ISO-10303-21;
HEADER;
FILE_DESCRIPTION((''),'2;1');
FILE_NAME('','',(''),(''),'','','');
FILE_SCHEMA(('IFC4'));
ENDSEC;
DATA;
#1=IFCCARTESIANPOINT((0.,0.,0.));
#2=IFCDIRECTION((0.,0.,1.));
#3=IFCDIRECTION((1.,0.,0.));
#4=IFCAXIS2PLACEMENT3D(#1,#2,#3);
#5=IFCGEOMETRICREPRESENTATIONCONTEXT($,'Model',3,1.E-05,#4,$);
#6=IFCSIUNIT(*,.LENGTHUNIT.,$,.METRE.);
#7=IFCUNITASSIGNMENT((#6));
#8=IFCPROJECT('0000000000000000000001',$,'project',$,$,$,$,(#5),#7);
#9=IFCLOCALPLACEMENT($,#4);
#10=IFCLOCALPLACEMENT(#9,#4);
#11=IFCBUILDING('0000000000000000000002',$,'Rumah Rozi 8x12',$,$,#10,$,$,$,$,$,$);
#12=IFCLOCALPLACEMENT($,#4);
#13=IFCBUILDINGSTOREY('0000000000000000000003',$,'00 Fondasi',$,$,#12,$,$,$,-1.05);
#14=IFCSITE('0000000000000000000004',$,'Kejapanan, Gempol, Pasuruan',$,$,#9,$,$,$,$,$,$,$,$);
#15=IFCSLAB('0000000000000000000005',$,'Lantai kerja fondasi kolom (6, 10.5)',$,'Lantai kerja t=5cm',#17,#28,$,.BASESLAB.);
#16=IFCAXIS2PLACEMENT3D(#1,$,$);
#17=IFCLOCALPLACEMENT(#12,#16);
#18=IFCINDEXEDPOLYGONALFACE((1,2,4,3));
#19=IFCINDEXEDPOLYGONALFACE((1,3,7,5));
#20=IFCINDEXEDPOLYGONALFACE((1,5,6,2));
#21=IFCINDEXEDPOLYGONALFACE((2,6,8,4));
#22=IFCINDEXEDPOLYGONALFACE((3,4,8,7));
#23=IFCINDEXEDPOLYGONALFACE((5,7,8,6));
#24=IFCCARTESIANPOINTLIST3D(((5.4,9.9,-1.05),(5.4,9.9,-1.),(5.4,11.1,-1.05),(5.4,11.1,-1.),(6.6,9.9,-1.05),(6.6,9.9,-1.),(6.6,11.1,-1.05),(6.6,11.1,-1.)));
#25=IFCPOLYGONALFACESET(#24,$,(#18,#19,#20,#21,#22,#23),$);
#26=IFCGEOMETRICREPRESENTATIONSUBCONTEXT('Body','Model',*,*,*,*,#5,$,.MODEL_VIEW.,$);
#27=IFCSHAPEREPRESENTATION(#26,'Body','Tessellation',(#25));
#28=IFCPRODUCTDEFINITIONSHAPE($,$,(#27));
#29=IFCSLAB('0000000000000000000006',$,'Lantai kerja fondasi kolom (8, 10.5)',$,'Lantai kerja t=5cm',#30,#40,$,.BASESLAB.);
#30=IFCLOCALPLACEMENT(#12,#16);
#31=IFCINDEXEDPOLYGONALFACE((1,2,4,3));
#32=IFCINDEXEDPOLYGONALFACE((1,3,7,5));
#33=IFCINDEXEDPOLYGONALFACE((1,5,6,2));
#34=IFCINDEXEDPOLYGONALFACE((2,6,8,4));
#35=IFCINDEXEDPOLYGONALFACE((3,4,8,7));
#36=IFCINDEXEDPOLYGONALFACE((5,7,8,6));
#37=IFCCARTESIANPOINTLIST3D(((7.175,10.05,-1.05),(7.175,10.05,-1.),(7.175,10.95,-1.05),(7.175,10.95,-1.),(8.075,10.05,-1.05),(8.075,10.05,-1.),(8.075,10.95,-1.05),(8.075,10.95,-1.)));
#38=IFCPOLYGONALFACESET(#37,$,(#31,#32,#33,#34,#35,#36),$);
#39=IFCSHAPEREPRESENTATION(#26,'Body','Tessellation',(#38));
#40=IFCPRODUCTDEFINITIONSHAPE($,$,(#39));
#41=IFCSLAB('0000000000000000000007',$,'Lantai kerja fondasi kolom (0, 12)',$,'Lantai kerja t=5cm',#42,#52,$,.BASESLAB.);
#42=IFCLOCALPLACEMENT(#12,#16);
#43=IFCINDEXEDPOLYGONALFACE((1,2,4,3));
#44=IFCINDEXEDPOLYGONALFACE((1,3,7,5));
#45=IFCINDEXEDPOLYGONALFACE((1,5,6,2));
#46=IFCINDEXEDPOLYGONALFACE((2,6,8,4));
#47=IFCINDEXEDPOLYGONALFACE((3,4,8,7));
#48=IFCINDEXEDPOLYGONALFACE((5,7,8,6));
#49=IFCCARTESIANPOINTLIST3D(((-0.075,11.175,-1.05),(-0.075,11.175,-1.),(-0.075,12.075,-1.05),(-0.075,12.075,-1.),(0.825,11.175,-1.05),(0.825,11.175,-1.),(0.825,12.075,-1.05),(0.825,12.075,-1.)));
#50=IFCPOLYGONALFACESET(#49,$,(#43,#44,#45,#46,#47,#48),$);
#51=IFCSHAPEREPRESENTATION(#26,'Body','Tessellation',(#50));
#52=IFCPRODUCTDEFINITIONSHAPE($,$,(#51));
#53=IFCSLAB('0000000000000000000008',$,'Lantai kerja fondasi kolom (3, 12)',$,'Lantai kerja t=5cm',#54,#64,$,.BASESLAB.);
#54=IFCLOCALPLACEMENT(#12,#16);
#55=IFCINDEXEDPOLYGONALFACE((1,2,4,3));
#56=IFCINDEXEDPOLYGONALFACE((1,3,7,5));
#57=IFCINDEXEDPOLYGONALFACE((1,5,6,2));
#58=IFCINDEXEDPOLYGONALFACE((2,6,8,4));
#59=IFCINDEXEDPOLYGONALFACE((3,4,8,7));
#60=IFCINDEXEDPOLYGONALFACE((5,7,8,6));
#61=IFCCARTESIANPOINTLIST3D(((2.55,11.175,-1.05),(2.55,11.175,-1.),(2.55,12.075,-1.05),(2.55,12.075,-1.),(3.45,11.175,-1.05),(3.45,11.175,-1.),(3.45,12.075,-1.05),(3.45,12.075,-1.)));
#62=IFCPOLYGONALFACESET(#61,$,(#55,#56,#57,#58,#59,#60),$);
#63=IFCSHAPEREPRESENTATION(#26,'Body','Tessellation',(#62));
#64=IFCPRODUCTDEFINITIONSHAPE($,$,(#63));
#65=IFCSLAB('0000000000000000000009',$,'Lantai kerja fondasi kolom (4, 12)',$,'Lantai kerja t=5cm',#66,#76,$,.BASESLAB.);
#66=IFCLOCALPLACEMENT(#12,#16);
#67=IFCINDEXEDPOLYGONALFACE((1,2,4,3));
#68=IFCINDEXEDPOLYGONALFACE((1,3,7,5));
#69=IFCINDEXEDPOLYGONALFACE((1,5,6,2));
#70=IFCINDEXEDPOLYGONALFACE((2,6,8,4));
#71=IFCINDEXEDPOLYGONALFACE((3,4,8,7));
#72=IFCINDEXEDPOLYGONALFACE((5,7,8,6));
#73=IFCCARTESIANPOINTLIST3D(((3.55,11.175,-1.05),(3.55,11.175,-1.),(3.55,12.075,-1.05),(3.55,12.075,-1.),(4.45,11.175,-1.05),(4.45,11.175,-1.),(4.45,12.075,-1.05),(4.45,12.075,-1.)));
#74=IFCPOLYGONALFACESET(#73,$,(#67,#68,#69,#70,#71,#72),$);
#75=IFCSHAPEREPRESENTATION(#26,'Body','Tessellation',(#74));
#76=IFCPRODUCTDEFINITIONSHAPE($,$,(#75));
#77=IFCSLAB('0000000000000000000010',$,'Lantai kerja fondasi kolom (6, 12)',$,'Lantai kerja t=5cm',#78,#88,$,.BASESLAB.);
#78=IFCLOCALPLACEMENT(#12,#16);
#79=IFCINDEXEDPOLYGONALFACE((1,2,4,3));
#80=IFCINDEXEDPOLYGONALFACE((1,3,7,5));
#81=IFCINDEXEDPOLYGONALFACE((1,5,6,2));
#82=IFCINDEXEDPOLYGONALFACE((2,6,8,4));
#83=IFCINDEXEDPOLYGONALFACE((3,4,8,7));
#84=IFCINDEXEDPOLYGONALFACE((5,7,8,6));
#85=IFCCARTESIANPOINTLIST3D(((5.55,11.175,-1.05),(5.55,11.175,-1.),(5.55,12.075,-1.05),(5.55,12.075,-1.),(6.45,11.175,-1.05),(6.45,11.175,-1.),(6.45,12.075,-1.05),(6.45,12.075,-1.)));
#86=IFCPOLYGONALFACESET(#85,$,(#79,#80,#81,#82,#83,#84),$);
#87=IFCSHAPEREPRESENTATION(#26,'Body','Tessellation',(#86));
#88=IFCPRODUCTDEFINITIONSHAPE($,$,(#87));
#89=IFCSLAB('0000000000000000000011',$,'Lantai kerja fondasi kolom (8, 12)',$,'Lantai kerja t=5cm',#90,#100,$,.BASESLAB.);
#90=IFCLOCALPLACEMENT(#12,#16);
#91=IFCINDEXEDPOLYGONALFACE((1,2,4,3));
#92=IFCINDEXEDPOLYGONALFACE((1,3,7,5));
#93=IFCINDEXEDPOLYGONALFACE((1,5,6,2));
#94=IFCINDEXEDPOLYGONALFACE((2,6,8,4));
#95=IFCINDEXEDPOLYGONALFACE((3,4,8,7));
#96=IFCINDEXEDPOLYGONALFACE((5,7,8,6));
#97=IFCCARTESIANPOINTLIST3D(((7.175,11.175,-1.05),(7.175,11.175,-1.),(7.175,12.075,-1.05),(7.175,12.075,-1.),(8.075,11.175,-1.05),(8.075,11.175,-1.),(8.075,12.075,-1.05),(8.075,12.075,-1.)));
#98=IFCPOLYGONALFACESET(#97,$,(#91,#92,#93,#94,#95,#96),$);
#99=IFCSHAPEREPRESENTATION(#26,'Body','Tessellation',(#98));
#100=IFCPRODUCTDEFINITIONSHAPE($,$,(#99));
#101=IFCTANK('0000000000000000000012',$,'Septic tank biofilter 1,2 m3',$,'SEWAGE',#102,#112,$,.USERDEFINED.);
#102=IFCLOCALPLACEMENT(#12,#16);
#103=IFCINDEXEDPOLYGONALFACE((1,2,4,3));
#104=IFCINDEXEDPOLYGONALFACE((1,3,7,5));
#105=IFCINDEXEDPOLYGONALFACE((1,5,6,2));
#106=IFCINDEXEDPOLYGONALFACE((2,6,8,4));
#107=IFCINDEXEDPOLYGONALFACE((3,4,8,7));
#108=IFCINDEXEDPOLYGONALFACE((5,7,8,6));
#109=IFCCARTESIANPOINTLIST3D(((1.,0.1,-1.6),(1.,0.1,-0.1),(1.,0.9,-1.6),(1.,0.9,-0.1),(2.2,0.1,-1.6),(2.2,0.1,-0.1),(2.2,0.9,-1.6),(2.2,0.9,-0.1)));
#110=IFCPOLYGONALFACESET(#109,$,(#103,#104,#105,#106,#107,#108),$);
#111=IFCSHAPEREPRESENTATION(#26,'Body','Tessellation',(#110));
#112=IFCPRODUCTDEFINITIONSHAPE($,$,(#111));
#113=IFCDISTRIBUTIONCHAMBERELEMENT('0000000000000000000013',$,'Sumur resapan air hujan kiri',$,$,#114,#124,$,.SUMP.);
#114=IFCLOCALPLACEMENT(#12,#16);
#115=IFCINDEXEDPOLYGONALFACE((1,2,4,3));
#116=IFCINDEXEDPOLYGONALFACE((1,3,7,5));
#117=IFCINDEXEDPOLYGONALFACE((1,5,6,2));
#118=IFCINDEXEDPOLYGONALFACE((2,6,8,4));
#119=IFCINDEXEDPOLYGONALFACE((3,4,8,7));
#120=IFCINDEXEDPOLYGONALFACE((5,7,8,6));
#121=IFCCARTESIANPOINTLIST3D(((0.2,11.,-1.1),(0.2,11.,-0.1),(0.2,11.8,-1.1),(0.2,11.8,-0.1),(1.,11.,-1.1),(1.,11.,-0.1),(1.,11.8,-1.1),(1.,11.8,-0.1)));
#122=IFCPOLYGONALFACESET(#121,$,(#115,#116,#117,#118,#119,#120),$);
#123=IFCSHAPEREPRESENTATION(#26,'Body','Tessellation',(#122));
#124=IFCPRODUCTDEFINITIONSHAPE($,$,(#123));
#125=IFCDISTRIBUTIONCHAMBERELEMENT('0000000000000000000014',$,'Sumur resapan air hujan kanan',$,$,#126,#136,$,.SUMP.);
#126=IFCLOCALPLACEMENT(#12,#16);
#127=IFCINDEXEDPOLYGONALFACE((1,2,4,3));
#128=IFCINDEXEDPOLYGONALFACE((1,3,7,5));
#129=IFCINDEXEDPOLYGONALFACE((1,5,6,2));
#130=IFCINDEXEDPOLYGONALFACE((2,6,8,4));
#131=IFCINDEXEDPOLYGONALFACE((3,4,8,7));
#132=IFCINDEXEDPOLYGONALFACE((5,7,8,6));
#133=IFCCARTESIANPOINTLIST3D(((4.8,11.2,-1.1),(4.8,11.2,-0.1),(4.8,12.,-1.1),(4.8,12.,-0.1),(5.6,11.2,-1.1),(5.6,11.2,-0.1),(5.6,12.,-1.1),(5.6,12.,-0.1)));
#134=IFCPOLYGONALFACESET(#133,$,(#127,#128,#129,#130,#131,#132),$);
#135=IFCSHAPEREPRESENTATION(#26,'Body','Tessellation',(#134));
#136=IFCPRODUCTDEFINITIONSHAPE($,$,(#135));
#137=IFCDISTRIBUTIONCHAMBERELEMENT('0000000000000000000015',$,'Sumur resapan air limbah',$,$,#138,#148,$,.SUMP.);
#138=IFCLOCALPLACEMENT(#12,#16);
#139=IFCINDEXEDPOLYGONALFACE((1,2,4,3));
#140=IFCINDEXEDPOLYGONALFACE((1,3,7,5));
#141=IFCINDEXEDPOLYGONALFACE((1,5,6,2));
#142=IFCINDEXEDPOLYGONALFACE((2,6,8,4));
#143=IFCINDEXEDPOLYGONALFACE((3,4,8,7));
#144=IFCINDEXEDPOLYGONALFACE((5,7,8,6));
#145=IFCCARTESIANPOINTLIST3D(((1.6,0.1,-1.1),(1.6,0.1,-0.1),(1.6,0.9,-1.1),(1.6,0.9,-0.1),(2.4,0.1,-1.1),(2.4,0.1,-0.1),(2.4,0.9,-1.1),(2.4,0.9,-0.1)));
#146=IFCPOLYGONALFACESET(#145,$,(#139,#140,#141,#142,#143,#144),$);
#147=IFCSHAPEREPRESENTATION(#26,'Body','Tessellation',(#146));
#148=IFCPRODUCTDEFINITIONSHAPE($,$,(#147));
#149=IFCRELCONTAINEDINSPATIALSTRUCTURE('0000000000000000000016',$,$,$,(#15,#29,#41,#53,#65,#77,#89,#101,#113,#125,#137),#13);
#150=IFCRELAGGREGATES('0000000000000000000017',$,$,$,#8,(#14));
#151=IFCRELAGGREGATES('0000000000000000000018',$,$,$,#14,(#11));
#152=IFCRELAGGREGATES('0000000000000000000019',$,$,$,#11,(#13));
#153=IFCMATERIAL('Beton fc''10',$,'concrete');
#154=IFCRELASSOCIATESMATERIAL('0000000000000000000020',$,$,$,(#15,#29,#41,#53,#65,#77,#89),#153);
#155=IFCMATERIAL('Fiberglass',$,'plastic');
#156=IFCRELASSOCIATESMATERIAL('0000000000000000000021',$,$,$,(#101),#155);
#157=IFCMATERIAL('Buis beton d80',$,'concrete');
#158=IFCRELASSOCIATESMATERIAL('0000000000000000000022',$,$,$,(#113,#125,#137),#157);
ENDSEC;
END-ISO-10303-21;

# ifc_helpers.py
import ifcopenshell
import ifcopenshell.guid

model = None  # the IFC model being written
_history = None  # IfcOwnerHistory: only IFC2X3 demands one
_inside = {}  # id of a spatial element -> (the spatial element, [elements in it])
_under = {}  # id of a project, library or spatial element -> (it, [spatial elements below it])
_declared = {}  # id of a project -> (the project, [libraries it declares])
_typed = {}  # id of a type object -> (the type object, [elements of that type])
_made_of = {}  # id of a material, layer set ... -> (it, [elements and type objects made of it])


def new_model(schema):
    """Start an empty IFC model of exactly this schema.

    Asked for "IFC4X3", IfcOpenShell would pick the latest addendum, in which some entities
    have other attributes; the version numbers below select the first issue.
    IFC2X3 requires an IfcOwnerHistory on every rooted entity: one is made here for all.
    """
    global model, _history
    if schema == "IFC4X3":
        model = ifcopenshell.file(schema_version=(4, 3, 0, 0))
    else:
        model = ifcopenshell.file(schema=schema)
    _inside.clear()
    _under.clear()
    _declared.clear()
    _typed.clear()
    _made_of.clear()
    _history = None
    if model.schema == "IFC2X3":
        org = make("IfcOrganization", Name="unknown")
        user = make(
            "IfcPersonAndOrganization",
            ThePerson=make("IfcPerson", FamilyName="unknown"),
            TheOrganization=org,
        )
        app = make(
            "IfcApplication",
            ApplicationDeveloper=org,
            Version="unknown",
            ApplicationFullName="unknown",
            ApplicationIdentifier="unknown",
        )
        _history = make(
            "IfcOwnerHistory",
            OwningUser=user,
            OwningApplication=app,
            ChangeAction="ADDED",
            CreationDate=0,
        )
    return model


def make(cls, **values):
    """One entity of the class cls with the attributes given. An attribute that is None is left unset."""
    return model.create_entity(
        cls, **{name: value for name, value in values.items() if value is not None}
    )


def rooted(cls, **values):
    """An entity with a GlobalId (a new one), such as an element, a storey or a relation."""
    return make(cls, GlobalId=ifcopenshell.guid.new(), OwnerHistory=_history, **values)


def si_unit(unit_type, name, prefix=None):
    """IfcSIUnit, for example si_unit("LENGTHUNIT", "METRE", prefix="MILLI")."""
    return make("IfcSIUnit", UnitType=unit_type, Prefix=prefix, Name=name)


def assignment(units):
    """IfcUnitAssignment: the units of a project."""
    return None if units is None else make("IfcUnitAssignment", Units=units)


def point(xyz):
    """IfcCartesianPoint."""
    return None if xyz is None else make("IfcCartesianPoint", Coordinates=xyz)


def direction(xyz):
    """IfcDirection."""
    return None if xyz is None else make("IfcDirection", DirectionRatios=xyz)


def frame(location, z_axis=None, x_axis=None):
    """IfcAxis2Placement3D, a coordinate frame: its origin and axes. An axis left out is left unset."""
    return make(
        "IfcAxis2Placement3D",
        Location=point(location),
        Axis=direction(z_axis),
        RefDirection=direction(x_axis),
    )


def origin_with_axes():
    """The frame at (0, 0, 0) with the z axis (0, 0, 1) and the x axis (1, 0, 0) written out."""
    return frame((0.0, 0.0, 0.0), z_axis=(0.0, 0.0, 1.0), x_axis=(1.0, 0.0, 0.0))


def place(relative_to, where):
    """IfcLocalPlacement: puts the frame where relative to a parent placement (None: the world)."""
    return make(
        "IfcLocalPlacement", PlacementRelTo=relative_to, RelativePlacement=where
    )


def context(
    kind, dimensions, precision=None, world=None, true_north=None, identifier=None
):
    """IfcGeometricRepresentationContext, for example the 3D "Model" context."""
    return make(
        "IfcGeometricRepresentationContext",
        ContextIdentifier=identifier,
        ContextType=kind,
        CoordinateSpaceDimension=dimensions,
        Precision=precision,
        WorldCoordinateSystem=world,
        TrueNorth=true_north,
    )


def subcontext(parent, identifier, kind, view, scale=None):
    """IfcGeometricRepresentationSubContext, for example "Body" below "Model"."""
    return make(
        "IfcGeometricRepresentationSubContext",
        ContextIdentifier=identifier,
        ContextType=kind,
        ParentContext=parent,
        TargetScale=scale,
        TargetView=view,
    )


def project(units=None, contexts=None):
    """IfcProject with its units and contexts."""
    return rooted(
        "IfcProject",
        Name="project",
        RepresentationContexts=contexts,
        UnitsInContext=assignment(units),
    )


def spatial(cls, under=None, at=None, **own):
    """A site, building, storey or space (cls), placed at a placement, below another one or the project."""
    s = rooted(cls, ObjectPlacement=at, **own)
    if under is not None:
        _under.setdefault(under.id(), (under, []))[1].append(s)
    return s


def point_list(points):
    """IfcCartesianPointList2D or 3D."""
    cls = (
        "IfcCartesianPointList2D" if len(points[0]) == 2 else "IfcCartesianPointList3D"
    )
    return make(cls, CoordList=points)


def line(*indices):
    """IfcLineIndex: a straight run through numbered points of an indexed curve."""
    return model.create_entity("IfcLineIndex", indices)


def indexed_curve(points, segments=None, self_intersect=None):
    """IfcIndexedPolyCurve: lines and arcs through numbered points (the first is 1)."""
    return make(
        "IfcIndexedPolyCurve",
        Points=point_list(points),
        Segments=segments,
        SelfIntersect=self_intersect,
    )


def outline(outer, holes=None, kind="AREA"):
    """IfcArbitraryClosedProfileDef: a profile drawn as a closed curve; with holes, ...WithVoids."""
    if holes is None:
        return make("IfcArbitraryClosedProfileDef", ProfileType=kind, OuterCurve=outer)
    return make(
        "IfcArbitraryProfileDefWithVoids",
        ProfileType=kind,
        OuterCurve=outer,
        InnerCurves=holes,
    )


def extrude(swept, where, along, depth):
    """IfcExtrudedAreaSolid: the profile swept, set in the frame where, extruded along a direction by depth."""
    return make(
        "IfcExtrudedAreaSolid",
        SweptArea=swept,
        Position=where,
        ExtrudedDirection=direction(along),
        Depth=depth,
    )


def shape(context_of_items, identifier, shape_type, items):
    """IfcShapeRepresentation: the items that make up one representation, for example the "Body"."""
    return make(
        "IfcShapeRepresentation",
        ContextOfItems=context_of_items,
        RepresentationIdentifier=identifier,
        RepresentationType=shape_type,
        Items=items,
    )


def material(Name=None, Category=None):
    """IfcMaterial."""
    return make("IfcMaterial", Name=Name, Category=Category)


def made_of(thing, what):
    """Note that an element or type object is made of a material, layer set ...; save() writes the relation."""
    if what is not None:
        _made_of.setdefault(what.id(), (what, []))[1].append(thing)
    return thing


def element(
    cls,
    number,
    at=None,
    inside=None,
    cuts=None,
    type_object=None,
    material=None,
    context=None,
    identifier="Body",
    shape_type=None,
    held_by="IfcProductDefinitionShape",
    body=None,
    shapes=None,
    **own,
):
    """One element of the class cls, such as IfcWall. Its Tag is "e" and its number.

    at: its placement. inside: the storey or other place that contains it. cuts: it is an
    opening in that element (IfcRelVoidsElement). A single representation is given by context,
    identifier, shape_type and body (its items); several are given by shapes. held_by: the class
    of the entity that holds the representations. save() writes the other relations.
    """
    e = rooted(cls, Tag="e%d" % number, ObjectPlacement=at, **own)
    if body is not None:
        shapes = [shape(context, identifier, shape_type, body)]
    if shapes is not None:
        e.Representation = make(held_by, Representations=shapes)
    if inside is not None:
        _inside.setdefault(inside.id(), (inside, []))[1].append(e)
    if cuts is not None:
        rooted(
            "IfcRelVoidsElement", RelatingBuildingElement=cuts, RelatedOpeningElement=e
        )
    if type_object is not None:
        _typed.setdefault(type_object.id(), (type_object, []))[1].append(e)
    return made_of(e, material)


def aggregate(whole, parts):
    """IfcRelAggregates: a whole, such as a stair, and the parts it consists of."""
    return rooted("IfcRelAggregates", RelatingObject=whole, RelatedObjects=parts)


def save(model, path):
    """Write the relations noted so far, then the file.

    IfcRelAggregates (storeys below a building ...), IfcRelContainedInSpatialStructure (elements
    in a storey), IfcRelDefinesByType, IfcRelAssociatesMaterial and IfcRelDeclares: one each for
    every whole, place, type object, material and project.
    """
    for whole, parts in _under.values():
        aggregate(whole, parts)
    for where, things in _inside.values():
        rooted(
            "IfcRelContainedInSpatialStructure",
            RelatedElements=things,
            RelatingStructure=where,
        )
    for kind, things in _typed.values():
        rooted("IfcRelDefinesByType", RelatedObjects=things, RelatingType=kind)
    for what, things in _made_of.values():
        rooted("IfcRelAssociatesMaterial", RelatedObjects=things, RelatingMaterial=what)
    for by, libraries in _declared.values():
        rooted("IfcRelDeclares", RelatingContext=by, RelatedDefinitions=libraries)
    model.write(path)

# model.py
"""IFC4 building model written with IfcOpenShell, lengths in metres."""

from ifc_helpers import new_model, si_unit, frame, origin_with_axes, place, context, subcontext, project, spatial, line, indexed_curve, outline, extrude, material, element, save


model = new_model("IFC4")

# Units and contexts
model_context = context("Model", 3, precision=1e-05, world=origin_with_axes())
body_context = subcontext(model_context, "Body", "Model", "MODEL_VIEW")
ifc_project = project(units=[si_unit("LENGTHUNIT", "METRE")], contexts=[model_context])

# Site, building, storey
site_placement = place(None, origin_with_axes())
site = spatial("IfcSite", under=ifc_project, at=site_placement, Name="Kejapanan, Gempol, Pasuruan")
building_placement = place(site_placement, origin_with_axes())
building = spatial("IfcBuilding", under=site, at=building_placement, Name="Rumah Rozi 8x12")
storey_placement = place(None, origin_with_axes())
storey = spatial("IfcBuildingStorey", under=building, at=storey_placement, Name="00 Fondasi", Elevation=-1.05)

# Slabs
ifc_material_1 = material(Name="Beton fc'10", Category="concrete")
slab_1_placement = place(storey_placement, origin_with_axes())
element("IfcSlab", 1, at=slab_1_placement, inside=storey, material=ifc_material_1, Name="Lantai kerja fondasi kolom (6, 10.5)", ObjectType="Lantai kerja t=5cm", PredefinedType="BASESLAB", context=body_context, shape_type="SweptSolid", body=[
    extrude(outline(indexed_curve([(5.4, 9.9), (6.6, 9.9), (6.6, 11.1), (5.4, 11.1)], segments=[line(1, 2, 3, 4, 1)])), frame((0.0, 0.0, -1.05), z_axis=(0.0, 0.0, 1.0), x_axis=(1.0, 0.0, 0.0)), (0.0, 0.0, 1.0), 0.05),
])
slab_2_placement = place(storey_placement, origin_with_axes())
element("IfcSlab", 2, at=slab_2_placement, inside=storey, material=ifc_material_1, Name="Lantai kerja fondasi kolom (8, 10.5)", ObjectType="Lantai kerja t=5cm", PredefinedType="BASESLAB", context=body_context, shape_type="SweptSolid", body=[
    extrude(outline(indexed_curve([(7.175, 10.05), (8.075, 10.05), (8.075, 10.95), (7.175, 10.95)], segments=[line(1, 2, 3, 4, 1)])), frame((0.0, 0.0, -1.05), z_axis=(0.0, 0.0, 1.0), x_axis=(1.0, 0.0, 0.0)), (0.0, 0.0, 1.0), 0.05),
])
slab_3_placement = place(storey_placement, origin_with_axes())
element("IfcSlab", 3, at=slab_3_placement, inside=storey, material=ifc_material_1, Name="Lantai kerja fondasi kolom (0, 12)", ObjectType="Lantai kerja t=5cm", PredefinedType="BASESLAB", context=body_context, shape_type="SweptSolid", body=[
    extrude(outline(indexed_curve([(-0.075, 11.175), (0.825, 11.175), (0.825, 12.075), (-0.075, 12.075)], segments=[line(1, 2, 3, 4, 1)])), frame((0.0, 0.0, -1.05), z_axis=(0.0, 0.0, 1.0), x_axis=(1.0, 0.0, 0.0)), (0.0, 0.0, 1.0), 0.05),
])
slab_4_placement = place(storey_placement, origin_with_axes())
element("IfcSlab", 4, at=slab_4_placement, inside=storey, material=ifc_material_1, Name="Lantai kerja fondasi kolom (3, 12)", ObjectType="Lantai kerja t=5cm", PredefinedType="BASESLAB", context=body_context, shape_type="SweptSolid", body=[
    extrude(outline(indexed_curve([(2.55, 11.175), (3.45, 11.175), (3.45, 12.075), (2.55, 12.075)], segments=[line(1, 2, 3, 4, 1)])), frame((0.0, 0.0, -1.05), z_axis=(0.0, 0.0, 1.0), x_axis=(1.0, 0.0, 0.0)), (0.0, 0.0, 1.0), 0.05),
])
slab_5_placement = place(storey_placement, origin_with_axes())
element("IfcSlab", 5, at=slab_5_placement, inside=storey, material=ifc_material_1, Name="Lantai kerja fondasi kolom (4, 12)", ObjectType="Lantai kerja t=5cm", PredefinedType="BASESLAB", context=body_context, shape_type="SweptSolid", body=[
    extrude(outline(indexed_curve([(3.55, 11.175), (4.45, 11.175), (4.45, 12.075), (3.55, 12.075)], segments=[line(1, 2, 3, 4, 1)])), frame((0.0, 0.0, -1.05), z_axis=(0.0, 0.0, 1.0), x_axis=(1.0, 0.0, 0.0)), (0.0, 0.0, 1.0), 0.05),
])
slab_6_placement = place(storey_placement, origin_with_axes())
element("IfcSlab", 6, at=slab_6_placement, inside=storey, material=ifc_material_1, Name="Lantai kerja fondasi kolom (6, 12)", ObjectType="Lantai kerja t=5cm", PredefinedType="BASESLAB", context=body_context, shape_type="SweptSolid", body=[
    extrude(outline(indexed_curve([(5.55, 11.175), (6.45, 11.175), (6.45, 12.075), (5.55, 12.075)], segments=[line(1, 2, 3, 4, 1)])), frame((0.0, 0.0, -1.05), z_axis=(0.0, 0.0, 1.0), x_axis=(1.0, 0.0, 0.0)), (0.0, 0.0, 1.0), 0.05),
])
slab_7_placement = place(storey_placement, origin_with_axes())
element("IfcSlab", 7, at=slab_7_placement, inside=storey, material=ifc_material_1, Name="Lantai kerja fondasi kolom (8, 12)", ObjectType="Lantai kerja t=5cm", PredefinedType="BASESLAB", context=body_context, shape_type="SweptSolid", body=[
    extrude(outline(indexed_curve([(7.175, 11.175), (8.075, 11.175), (8.075, 12.075), (7.175, 12.075)], segments=[line(1, 2, 3, 4, 1)])), frame((0.0, 0.0, -1.05), z_axis=(0.0, 0.0, 1.0), x_axis=(1.0, 0.0, 0.0)), (0.0, 0.0, 1.0), 0.05),
])

# Tank
ifc_material_2 = material(Name="Fiberglass", Category="plastic")
tank_placement = place(storey_placement, origin_with_axes())
element("IfcTank", 8, at=tank_placement, inside=storey, material=ifc_material_2, Name="Septic tank biofilter 1,2 m3", ObjectType="SEWAGE", PredefinedType="USERDEFINED", context=body_context, shape_type="SweptSolid", body=[
    extrude(outline(indexed_curve([(1.0, 0.1), (2.2, 0.1), (2.2, 0.9), (1.0, 0.9)], segments=[line(1, 2, 3, 4, 1)])), frame((0.0, 0.0, -1.6), z_axis=(0.0, 0.0, 1.0), x_axis=(1.0, 0.0, 0.0)), (0.0, 0.0, 1.0), 1.5),
])

# Distribution chamber elements
ifc_material_3 = material(Name="Buis beton d80", Category="concrete")
distribution_chamber_element_1_placement = place(storey_placement, origin_with_axes())
element("IfcDistributionChamberElement", 9, at=distribution_chamber_element_1_placement, inside=storey, material=ifc_material_3, Name="Sumur resapan air hujan kiri", PredefinedType="SUMP", context=body_context, shape_type="SweptSolid", body=[
    extrude(outline(indexed_curve([(0.2, 11.0), (1.0, 11.0), (1.0, 11.8), (0.2, 11.8)], segments=[line(1, 2, 3, 4, 1)])), frame((0.0, 0.0, -1.1), z_axis=(0.0, 0.0, 1.0), x_axis=(1.0, 0.0, 0.0)), (0.0, 0.0, 1.0), 1.0),
])
distribution_chamber_element_2_placement = place(storey_placement, origin_with_axes())
element("IfcDistributionChamberElement", 10, at=distribution_chamber_element_2_placement, inside=storey, material=ifc_material_3, Name="Sumur resapan air hujan kanan", PredefinedType="SUMP", context=body_context, shape_type="SweptSolid", body=[
    extrude(outline(indexed_curve([(4.8, 11.2), (5.6, 11.2), (5.6, 12.0), (4.8, 12.0)], segments=[line(1, 2, 3, 4, 1)])), frame((0.0, 0.0, -1.1), z_axis=(0.0, 0.0, 1.0), x_axis=(1.0, 0.0, 0.0)), (0.0, 0.0, 1.0), 1.0),
])
distribution_chamber_element_3_placement = place(storey_placement, origin_with_axes())
element("IfcDistributionChamberElement", 11, at=distribution_chamber_element_3_placement, inside=storey, material=ifc_material_3, Name="Sumur resapan air limbah", PredefinedType="SUMP", context=body_context, shape_type="SweptSolid", body=[
    extrude(outline(indexed_curve([(1.6, 0.1), (2.4, 0.1), (2.4, 0.9), (1.6, 0.9)], segments=[line(1, 2, 3, 4, 1)])), frame((0.0, 0.0, -1.1), z_axis=(0.0, 0.0, 1.0), x_axis=(1.0, 0.0, 0.0)), (0.0, 0.0, 1.0), 1.0),
])

save(model, "model.ifc")
